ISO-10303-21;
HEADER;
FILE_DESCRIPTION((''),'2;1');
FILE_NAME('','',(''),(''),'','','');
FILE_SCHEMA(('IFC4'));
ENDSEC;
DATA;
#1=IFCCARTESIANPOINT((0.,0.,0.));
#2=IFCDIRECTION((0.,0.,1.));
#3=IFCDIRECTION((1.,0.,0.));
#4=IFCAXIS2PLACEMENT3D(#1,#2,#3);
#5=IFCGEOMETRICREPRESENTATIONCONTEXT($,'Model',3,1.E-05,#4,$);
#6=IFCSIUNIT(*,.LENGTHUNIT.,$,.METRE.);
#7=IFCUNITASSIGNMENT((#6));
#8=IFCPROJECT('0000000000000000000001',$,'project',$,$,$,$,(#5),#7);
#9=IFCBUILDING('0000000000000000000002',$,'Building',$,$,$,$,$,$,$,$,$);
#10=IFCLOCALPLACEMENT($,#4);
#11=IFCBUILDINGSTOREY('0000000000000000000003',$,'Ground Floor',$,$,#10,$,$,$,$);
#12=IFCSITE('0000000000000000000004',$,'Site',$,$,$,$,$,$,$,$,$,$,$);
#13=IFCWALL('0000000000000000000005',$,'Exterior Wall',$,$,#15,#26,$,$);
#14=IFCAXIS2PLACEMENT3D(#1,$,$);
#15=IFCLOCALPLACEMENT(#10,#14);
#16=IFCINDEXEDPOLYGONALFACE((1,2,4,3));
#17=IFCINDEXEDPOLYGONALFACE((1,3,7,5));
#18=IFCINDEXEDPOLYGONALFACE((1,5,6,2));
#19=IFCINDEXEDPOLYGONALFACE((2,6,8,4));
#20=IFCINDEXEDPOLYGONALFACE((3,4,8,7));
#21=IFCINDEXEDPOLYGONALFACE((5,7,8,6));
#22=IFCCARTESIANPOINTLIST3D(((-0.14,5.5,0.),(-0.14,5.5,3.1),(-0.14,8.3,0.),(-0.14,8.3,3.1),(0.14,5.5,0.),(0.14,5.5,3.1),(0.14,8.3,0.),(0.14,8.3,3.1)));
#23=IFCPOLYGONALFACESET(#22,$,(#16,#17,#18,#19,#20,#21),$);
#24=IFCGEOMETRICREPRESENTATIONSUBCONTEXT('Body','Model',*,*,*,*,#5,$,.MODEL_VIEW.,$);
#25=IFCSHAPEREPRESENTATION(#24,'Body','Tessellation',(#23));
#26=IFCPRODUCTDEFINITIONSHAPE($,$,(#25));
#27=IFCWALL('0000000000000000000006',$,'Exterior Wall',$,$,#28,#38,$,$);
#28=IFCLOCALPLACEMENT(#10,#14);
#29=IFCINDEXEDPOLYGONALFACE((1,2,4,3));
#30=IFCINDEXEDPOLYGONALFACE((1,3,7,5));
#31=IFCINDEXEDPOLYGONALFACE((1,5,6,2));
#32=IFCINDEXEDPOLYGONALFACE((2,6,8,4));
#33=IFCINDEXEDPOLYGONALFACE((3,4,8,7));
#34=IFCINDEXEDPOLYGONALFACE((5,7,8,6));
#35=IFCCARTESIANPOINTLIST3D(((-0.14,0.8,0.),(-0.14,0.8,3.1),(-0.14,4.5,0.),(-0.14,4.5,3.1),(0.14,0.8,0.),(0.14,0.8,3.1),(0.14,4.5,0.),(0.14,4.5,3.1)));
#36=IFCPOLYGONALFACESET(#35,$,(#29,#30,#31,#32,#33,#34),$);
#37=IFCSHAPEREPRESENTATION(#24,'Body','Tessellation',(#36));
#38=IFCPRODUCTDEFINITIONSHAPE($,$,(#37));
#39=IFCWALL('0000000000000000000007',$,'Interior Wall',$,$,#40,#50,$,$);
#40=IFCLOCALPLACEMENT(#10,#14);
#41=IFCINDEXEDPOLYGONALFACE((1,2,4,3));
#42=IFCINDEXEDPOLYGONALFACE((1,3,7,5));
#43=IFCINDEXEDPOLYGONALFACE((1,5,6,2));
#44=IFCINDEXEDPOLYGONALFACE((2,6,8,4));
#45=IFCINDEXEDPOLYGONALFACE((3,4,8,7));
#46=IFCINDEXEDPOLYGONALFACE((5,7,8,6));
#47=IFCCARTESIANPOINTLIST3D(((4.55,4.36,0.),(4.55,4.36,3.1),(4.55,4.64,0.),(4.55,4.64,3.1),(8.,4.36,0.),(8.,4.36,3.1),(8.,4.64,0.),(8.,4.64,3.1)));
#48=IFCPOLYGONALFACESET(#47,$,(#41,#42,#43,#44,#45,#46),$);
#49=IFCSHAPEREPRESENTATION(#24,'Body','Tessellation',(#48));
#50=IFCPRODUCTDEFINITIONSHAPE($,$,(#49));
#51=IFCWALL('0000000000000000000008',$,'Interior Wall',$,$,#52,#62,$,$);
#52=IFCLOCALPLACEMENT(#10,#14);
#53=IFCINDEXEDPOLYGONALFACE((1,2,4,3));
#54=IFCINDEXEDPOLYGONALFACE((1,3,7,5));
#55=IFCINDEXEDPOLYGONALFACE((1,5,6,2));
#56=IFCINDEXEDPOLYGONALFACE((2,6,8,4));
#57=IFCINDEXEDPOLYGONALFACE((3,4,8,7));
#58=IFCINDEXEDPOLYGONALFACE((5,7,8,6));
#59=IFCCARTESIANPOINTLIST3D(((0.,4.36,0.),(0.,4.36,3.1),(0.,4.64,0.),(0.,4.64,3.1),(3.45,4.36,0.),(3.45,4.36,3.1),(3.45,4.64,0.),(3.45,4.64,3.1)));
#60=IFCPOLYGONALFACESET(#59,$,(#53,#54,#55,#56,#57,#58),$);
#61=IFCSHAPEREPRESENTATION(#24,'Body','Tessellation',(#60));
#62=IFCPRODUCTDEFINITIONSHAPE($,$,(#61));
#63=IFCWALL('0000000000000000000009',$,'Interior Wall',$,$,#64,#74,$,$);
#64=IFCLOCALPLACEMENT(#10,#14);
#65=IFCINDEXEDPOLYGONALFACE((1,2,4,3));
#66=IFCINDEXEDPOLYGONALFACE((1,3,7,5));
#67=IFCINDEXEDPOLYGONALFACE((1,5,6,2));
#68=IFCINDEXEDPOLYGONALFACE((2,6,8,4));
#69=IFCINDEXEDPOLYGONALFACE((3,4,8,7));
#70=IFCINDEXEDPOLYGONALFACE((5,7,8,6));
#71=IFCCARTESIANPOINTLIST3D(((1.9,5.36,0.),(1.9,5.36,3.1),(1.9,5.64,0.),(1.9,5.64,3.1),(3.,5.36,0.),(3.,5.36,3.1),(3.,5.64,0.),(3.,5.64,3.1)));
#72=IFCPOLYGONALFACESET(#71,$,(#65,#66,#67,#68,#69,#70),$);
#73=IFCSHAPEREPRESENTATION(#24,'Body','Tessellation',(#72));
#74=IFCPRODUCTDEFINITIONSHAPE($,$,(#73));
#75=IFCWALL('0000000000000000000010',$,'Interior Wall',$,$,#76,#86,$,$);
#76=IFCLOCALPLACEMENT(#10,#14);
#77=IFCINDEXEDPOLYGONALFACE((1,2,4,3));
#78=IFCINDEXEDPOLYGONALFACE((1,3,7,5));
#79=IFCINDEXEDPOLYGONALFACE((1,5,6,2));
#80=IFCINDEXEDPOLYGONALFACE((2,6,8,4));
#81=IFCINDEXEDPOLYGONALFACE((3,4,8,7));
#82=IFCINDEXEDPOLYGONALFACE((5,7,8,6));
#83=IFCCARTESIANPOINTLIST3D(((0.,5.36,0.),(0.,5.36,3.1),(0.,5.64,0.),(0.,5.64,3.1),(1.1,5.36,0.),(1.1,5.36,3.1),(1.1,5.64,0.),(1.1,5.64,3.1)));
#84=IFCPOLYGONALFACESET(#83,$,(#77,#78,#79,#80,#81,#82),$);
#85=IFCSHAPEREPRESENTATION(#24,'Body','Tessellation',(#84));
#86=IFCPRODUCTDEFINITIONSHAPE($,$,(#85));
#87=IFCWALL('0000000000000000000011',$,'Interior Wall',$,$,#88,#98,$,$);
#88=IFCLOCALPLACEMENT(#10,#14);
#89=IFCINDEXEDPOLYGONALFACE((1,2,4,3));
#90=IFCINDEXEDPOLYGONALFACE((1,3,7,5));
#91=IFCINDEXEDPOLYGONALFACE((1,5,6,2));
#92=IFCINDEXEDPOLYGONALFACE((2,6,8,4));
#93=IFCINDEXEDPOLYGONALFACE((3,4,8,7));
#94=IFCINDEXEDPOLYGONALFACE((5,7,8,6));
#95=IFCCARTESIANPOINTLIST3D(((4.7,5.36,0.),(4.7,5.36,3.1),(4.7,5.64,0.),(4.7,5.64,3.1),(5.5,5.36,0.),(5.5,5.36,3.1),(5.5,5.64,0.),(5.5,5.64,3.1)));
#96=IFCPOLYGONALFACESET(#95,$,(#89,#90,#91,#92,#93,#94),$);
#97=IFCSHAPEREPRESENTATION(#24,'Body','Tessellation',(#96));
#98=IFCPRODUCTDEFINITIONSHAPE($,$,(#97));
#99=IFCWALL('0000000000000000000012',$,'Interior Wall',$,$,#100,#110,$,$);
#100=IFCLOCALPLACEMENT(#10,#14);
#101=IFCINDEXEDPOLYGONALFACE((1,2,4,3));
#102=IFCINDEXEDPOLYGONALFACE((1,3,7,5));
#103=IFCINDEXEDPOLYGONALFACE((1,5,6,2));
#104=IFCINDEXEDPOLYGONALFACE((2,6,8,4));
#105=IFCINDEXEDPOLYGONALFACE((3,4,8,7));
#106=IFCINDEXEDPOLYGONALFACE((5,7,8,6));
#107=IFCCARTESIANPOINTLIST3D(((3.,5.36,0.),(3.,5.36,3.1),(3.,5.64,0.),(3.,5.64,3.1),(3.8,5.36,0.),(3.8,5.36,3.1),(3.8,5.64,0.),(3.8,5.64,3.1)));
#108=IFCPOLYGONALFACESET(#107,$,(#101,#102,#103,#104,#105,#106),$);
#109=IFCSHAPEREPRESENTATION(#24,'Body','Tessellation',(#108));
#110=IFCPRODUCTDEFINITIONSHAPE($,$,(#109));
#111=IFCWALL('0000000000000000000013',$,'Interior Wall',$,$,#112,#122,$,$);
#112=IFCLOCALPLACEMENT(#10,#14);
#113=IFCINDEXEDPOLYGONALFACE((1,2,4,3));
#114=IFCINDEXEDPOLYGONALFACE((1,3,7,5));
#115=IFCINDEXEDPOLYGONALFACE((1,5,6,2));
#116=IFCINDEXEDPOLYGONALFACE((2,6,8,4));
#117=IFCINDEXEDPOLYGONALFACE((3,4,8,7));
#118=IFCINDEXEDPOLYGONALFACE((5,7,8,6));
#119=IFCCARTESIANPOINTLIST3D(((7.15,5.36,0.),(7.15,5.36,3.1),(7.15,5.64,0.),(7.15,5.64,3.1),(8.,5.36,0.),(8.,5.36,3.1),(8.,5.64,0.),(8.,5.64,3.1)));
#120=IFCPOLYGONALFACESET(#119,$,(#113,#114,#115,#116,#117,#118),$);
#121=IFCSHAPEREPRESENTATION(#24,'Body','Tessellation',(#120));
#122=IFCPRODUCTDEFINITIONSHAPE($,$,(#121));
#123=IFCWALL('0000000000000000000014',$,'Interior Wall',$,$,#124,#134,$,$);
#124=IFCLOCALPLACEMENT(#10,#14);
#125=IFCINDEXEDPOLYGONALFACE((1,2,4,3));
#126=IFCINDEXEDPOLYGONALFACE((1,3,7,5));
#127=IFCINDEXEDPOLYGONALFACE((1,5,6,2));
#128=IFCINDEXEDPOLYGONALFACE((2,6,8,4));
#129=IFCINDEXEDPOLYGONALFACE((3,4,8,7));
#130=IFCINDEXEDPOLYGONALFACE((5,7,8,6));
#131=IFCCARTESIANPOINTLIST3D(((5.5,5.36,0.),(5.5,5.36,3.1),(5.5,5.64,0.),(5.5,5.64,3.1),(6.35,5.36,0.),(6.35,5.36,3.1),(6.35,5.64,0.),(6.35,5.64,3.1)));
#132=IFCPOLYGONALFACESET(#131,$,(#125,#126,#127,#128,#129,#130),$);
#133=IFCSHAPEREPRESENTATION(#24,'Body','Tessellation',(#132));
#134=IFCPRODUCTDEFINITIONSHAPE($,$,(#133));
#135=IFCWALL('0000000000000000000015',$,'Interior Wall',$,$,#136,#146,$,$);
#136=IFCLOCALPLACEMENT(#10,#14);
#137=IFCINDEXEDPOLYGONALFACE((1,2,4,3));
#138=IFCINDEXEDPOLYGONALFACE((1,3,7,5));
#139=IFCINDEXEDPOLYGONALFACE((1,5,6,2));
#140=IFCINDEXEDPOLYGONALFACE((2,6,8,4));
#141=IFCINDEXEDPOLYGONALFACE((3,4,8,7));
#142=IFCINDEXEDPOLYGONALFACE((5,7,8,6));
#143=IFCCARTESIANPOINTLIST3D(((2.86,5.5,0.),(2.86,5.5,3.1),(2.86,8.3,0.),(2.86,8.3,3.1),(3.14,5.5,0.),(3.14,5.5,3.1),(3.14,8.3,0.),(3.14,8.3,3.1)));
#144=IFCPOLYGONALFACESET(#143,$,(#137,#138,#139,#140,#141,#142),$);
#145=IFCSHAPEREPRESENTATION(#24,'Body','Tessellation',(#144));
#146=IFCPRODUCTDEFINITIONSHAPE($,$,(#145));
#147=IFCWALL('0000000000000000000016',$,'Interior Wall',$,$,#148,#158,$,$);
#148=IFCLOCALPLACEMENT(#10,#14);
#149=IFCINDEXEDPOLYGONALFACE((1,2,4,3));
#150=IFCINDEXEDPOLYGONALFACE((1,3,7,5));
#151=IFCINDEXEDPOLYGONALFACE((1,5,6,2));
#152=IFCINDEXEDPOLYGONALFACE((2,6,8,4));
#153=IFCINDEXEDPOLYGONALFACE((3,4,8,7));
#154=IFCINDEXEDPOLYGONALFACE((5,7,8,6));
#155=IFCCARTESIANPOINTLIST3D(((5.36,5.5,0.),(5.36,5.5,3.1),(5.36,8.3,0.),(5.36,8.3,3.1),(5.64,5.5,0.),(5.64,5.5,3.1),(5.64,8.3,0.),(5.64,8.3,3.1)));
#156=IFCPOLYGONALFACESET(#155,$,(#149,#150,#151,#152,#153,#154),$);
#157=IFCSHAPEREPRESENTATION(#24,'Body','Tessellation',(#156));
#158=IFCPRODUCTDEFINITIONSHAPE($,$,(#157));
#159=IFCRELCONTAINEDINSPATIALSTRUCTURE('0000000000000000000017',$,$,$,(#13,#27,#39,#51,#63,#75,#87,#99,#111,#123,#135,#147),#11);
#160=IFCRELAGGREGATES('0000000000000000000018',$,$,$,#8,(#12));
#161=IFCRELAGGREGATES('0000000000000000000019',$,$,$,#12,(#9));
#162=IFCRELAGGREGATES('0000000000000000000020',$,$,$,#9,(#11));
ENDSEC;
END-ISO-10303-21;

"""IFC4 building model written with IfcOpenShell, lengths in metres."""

from ifc_helpers import new_model, si_unit, frame, origin_with_axes, place, context, subcontext, project, spatial, indexed_curve, outline, extrude, element, save


model = new_model("IFC4")

# Units and contexts
model_context = context("Model", 3, precision=1e-05, world=origin_with_axes())
body_context = subcontext(model_context, "Body", "Model", "MODEL_VIEW")
ifc_project = project(units=[si_unit("LENGTHUNIT", "METRE")], contexts=[model_context])

# Site, building, storey
site = spatial("IfcSite", under=ifc_project, Name="Site")
building = spatial("IfcBuilding", under=site, Name="Building")
storey_placement = place(None, origin_with_axes())
storey = spatial("IfcBuildingStorey", under=building, at=storey_placement, Name="Ground Floor")

# Walls
wall_1_placement = place(storey_placement, frame((0.0, 8.3, 0.0), z_axis=(0.0, 0.0, 1.0), x_axis=(0.0, -1.0, 0.0)))
element("IfcWall", 1, at=wall_1_placement, inside=storey, Name="Exterior Wall", context=body_context, shape_type="SweptSolid", body=[
    extrude(outline(indexed_curve([(0.0, 0.0), (0.0, 0.28), (2.8, 0.28), (2.8, 0.0), (0.0, 0.0)], self_intersect=False)), frame((0.0, -0.14, 0.0), z_axis=(0.0, 0.0, 1.0), x_axis=(1.0, 0.0, 0.0)), (0.0, 0.0, 1.0), 3.1),
])
wall_2_placement = place(storey_placement, frame((0.0, 4.5, 0.0), z_axis=(0.0, 0.0, 1.0), x_axis=(0.0, -1.0, 0.0)))
element("IfcWall", 2, at=wall_2_placement, inside=storey, Name="Exterior Wall", context=body_context, shape_type="SweptSolid", body=[
    extrude(outline(indexed_curve([(0.0, 0.0), (0.0, 0.28), (3.7, 0.28), (3.7, 0.0), (0.0, 0.0)], self_intersect=False)), frame((0.0, -0.14, 0.0), z_axis=(0.0, 0.0, 1.0), x_axis=(1.0, 0.0, 0.0)), (0.0, 0.0, 1.0), 3.1),
])
for number, where, z_axis, x_axis, name in (
    (3, (8.0, 4.5, 0.0), (0.0, 0.0, 1.0), (-1.0, 0.0, 0.0), "Interior Wall"),
    (4, (3.45, 4.5, 0.0), (0.0, 0.0, 1.0), (-1.0, 0.0, 0.0), "Interior Wall"),
):
    element("IfcWall", number, at=place(storey_placement, frame(where, z_axis=z_axis, x_axis=x_axis)), inside=storey, Name=name, context=body_context, shape_type="SweptSolid", body=[
        extrude(outline(indexed_curve([(0.0, 0.0), (0.0, 0.28), (3.45, 0.28), (3.45, 0.0), (0.0, 0.0)], self_intersect=False)), frame((0.0, -0.14, 0.0), z_axis=(0.0, 0.0, 1.0), x_axis=(1.0, 0.0, 0.0)), (0.0, 0.0, 1.0), 3.1),
    ])
for number, where, z_axis, x_axis, name in (
    (5, (3.0, 5.5, 0.0), (0.0, 0.0, 1.0), (-1.0, 0.0, 0.0), "Interior Wall"),
    (6, (1.1, 5.5, 0.0), (0.0, 0.0, 1.0), (-1.0, 0.0, 0.0), "Interior Wall"),
):
    element("IfcWall", number, at=place(storey_placement, frame(where, z_axis=z_axis, x_axis=x_axis)), inside=storey, Name=name, context=body_context, shape_type="SweptSolid", body=[
        extrude(outline(indexed_curve([(0.0, 0.0), (0.0, 0.28), (1.1, 0.28), (1.1, 0.0), (0.0, 0.0)], self_intersect=False)), frame((0.0, -0.14, 0.0), z_axis=(0.0, 0.0, 1.0), x_axis=(1.0, 0.0, 0.0)), (0.0, 0.0, 1.0), 3.1),
    ])
for number, where, z_axis, x_axis, name in (
    (7, (5.5, 5.5, 0.0), (0.0, 0.0, 1.0), (-1.0, 0.0, 0.0), "Interior Wall"),
    (8, (3.8, 5.5, 0.0), (0.0, 0.0, 1.0), (-1.0, 0.0, 0.0), "Interior Wall"),
):
    element("IfcWall", number, at=place(storey_placement, frame(where, z_axis=z_axis, x_axis=x_axis)), inside=storey, Name=name, context=body_context, shape_type="SweptSolid", body=[
        extrude(outline(indexed_curve([(0.0, 0.0), (0.0, 0.28), (0.8, 0.28), (0.8, 0.0), (0.0, 0.0)], self_intersect=False)), frame((0.0, -0.14, 0.0), z_axis=(0.0, 0.0, 1.0), x_axis=(1.0, 0.0, 0.0)), (0.0, 0.0, 1.0), 3.1),
    ])
for number, where, z_axis, x_axis, name in (
    (9, (8.0, 5.5, 0.0), (0.0, 0.0, 1.0), (-1.0, 0.0, 0.0), "Interior Wall"),
    (10, (6.35, 5.5, 0.0), (0.0, 0.0, 1.0), (-1.0, 0.0, 0.0), "Interior Wall"),
):
    element("IfcWall", number, at=place(storey_placement, frame(where, z_axis=z_axis, x_axis=x_axis)), inside=storey, Name=name, context=body_context, shape_type="SweptSolid", body=[
        extrude(outline(indexed_curve([(0.0, 0.0), (0.0, 0.28), (0.85, 0.28), (0.85, 0.0), (0.0, 0.0)], self_intersect=False)), frame((0.0, -0.14, 0.0), z_axis=(0.0, 0.0, 1.0), x_axis=(1.0, 0.0, 0.0)), (0.0, 0.0, 1.0), 3.1),
    ])
for number, where, z_axis, x_axis, name in (
    (11, (3.0, 5.5, 0.0), (0.0, 0.0, 1.0), (0.0, 1.0, 0.0), "Interior Wall"),
    (12, (5.5, 5.5, 0.0), (0.0, 0.0, 1.0), (0.0, 1.0, 0.0), "Interior Wall"),
):
    element("IfcWall", number, at=place(storey_placement, frame(where, z_axis=z_axis, x_axis=x_axis)), inside=storey, Name=name, context=body_context, shape_type="SweptSolid", body=[
        extrude(outline(indexed_curve([(0.0, 0.0), (0.0, 0.28), (2.8, 0.28), (2.8, 0.0), (0.0, 0.0)], self_intersect=False)), frame((0.0, -0.14, 0.0), z_axis=(0.0, 0.0, 1.0), x_axis=(1.0, 0.0, 0.0)), (0.0, 0.0, 1.0), 3.1),
    ])

save(model, "model.ifc")
